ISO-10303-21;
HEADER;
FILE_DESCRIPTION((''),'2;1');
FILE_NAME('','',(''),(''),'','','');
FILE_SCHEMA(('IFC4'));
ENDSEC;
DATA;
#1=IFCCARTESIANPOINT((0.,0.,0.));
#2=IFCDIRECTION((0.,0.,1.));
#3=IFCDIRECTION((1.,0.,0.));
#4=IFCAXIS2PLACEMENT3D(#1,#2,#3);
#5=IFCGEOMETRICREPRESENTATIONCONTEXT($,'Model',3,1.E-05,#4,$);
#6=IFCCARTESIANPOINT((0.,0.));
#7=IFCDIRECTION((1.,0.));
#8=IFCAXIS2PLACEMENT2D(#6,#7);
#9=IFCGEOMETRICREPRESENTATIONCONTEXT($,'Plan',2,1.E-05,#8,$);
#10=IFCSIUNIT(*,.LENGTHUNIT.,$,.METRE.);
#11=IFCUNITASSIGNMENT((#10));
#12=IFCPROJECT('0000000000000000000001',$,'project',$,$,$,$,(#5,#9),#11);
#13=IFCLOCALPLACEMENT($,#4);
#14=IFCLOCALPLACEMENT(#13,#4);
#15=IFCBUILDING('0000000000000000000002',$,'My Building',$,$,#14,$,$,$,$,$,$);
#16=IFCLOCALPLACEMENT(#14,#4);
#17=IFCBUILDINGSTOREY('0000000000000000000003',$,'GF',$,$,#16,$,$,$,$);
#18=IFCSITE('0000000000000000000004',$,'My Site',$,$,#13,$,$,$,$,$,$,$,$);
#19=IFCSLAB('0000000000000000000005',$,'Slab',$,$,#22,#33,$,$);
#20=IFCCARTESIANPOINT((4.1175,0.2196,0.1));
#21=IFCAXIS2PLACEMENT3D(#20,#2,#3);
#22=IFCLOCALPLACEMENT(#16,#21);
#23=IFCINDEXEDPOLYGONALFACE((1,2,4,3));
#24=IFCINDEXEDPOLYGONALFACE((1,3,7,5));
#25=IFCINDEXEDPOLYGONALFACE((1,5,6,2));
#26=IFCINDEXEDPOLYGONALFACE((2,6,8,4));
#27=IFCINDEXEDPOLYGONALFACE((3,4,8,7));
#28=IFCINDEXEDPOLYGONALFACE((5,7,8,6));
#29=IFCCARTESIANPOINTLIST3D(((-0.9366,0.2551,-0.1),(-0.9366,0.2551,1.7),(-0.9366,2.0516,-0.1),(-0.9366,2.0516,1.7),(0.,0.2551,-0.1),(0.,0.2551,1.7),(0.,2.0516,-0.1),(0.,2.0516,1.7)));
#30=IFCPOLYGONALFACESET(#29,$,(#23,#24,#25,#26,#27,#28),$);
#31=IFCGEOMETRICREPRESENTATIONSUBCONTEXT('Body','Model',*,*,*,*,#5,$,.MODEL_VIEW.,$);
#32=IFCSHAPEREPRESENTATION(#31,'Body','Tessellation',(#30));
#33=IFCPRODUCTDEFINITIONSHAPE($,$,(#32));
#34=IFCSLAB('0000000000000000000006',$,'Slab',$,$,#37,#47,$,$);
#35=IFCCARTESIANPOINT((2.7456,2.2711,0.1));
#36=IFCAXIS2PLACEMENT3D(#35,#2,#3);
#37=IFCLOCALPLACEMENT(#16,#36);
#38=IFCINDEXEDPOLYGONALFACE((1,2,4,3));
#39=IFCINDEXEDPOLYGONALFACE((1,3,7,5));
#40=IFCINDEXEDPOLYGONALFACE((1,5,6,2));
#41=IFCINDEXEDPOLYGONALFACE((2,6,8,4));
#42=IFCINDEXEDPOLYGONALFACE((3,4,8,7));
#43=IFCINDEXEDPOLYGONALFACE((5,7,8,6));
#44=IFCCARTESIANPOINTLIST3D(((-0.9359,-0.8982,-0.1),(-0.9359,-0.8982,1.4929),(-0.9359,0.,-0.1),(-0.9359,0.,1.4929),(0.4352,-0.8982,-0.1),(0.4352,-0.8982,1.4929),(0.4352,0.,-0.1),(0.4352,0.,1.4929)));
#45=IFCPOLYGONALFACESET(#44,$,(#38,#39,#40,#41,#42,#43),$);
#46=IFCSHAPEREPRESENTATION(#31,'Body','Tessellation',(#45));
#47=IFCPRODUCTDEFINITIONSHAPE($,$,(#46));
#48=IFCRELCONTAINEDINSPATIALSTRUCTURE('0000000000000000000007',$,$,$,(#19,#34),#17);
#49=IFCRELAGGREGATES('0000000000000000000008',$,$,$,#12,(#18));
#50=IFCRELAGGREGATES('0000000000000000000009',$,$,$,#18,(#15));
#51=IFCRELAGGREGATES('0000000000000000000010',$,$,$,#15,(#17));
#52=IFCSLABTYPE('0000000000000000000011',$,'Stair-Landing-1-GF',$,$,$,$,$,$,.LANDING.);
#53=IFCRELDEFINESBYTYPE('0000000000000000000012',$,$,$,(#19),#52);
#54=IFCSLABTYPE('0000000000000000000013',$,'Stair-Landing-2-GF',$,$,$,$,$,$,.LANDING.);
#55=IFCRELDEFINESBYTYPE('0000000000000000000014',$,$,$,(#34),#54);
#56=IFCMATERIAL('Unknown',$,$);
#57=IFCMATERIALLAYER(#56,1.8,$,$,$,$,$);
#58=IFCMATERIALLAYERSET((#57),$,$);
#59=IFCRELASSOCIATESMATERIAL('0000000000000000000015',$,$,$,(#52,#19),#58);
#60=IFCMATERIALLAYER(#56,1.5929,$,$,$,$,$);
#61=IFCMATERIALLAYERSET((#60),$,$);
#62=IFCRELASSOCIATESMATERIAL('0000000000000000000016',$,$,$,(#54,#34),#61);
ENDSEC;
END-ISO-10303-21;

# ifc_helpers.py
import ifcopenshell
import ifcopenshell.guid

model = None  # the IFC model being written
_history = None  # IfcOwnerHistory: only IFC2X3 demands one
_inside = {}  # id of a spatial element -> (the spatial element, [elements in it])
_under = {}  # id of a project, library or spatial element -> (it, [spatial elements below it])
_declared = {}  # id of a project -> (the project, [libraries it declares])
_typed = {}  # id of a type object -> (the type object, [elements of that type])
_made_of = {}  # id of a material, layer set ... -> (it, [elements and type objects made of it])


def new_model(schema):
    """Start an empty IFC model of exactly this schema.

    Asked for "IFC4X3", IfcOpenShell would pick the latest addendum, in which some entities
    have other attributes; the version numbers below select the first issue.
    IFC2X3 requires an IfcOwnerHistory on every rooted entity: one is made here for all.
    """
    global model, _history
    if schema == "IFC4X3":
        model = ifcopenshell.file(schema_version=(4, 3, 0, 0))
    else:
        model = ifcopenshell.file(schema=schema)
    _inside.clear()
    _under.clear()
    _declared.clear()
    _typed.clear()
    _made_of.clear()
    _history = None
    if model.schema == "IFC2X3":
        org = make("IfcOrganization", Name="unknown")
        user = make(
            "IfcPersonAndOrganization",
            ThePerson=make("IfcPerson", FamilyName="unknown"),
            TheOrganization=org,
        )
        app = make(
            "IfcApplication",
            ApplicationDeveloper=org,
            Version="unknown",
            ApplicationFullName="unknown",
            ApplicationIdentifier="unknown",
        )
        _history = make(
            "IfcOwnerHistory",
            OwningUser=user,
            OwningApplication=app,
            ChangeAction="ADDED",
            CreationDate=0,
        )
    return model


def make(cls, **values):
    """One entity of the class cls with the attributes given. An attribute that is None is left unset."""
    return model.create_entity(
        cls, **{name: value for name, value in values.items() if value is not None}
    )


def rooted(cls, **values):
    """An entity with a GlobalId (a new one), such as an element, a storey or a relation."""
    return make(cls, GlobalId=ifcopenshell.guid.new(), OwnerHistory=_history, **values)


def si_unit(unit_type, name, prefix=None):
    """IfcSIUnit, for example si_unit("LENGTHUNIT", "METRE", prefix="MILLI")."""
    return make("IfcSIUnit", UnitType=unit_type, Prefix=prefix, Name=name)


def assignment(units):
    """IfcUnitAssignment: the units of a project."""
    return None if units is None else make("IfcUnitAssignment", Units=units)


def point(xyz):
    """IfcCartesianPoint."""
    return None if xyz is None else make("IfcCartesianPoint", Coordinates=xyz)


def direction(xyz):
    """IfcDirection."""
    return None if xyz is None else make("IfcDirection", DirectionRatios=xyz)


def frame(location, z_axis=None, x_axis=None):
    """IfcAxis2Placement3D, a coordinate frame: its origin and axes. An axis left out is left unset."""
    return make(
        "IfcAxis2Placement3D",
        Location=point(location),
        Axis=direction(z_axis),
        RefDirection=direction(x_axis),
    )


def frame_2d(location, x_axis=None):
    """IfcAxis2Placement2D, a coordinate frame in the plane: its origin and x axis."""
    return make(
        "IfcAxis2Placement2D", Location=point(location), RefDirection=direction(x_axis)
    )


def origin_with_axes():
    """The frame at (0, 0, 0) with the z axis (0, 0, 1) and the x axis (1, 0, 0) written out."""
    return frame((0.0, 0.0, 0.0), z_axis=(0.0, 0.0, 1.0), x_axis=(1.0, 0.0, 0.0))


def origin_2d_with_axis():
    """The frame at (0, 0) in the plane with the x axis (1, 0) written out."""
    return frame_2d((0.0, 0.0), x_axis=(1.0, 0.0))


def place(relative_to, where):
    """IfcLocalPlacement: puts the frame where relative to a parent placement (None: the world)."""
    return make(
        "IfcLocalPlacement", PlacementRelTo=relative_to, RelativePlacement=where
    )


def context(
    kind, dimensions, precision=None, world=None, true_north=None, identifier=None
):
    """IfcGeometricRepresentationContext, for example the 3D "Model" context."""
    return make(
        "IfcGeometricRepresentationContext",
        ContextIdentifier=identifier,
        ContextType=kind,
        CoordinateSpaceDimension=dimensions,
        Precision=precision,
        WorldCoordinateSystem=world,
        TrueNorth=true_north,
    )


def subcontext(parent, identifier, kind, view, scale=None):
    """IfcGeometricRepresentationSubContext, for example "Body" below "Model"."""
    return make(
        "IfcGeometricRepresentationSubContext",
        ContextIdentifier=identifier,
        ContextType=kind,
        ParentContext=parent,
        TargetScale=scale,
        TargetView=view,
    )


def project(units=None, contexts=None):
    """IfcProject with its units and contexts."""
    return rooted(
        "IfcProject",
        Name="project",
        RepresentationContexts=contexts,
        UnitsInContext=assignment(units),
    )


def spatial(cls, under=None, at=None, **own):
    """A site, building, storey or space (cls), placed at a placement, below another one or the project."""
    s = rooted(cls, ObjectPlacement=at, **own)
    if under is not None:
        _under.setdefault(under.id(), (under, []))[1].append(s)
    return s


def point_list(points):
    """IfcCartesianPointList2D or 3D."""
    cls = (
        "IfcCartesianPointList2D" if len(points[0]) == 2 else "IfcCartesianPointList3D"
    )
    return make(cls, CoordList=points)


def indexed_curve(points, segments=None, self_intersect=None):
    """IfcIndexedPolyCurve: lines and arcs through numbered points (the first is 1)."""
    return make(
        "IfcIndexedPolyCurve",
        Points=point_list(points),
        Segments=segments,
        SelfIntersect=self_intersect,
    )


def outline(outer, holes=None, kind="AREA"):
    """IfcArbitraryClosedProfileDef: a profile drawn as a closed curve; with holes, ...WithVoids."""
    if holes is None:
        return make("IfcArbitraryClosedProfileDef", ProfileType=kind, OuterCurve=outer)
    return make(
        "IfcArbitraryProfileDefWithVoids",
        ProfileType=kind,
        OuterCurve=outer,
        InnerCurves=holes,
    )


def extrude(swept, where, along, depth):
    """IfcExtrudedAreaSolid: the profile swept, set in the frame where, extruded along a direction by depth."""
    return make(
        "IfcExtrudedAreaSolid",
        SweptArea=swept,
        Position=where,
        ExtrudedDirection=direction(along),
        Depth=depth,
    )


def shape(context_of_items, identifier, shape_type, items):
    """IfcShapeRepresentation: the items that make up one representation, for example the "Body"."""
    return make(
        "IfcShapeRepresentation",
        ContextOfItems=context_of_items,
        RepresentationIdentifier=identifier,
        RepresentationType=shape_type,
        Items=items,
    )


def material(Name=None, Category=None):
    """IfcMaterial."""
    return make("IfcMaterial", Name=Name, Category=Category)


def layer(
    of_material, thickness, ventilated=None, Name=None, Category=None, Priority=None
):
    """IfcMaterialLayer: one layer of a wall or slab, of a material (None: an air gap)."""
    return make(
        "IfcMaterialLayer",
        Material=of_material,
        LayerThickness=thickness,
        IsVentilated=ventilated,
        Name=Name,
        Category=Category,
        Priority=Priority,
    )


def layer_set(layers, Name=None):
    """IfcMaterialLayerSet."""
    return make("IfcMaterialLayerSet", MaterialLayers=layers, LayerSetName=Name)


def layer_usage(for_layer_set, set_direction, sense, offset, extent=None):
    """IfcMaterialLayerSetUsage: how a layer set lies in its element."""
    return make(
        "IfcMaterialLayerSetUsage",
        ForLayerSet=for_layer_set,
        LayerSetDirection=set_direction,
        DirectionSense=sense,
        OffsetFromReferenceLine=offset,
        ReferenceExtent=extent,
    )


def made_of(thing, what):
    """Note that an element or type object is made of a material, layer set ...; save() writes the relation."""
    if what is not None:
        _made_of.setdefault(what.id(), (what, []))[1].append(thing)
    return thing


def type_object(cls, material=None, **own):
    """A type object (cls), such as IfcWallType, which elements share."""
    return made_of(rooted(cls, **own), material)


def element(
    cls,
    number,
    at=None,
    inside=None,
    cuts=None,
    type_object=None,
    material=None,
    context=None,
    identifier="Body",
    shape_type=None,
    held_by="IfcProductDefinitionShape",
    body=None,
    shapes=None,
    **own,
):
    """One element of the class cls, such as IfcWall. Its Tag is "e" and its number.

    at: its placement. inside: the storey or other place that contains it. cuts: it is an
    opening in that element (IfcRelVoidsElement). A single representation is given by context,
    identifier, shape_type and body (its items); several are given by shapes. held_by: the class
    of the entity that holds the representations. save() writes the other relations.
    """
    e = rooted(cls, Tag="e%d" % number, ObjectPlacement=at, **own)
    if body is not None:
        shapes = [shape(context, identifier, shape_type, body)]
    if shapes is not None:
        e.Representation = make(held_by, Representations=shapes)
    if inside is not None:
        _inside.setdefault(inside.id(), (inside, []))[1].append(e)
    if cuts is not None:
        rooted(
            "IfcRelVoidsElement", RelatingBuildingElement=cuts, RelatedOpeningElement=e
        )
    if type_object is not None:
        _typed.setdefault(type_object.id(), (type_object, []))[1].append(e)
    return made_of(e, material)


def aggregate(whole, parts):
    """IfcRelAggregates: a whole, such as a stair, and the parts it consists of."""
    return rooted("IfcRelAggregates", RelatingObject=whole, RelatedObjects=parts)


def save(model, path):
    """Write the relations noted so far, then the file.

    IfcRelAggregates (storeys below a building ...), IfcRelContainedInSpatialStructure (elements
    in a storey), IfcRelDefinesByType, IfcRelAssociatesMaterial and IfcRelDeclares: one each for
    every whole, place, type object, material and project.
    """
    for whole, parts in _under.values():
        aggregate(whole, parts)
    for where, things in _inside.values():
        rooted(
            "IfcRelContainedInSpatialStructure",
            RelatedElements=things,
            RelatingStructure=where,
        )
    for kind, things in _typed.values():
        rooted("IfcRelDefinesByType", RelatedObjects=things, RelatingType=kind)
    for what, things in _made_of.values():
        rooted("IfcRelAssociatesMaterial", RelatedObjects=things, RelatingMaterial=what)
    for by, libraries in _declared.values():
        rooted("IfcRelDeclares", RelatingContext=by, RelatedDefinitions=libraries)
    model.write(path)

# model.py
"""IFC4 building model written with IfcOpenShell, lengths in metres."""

from ifc_helpers import new_model, si_unit, frame, origin_with_axes, origin_2d_with_axis, place, context, subcontext, project, spatial, indexed_curve, outline, extrude, material, layer, layer_set, layer_usage, type_object, element, save


model = new_model("IFC4")

# Units and contexts
model_context = context("Model", 3, precision=1e-05, world=origin_with_axes())
plan_context = context("Plan", 2, precision=1e-05, world=origin_2d_with_axis())
body_context_1 = subcontext(model_context, "Body", "Model", "MODEL_VIEW")
ifc_project = project(units=[si_unit("LENGTHUNIT", "METRE")], contexts=[model_context, plan_context])

# Site, building, storey
site_placement = place(None, origin_with_axes())
site = spatial("IfcSite", under=ifc_project, at=site_placement, Name="My Site")
building_placement = place(site_placement, origin_with_axes())
building = spatial("IfcBuilding", under=site, at=building_placement, Name="My Building")
storey_placement = place(building_placement, origin_with_axes())
storey = spatial("IfcBuildingStorey", under=building, at=storey_placement, Name="GF")

# Shared definitions
ifc_material = material(Name="Unknown")

# Slabs
ifc_layer_1 = layer(ifc_material, 1.8)
ifc_layer_set_1 = layer_set([ifc_layer_1])
ifc_layer_usage_1 = layer_usage(ifc_layer_set_1, "AXIS3", "POSITIVE", -0.1)
slab_type_1 = type_object("IfcSlabType", Name="Stair-Landing-1-GF", PredefinedType="LANDING", material=ifc_layer_set_1)
slab_1_placement = place(storey_placement, frame((4.1175, 0.2196, 0.1), z_axis=(0.0, 0.0, 1.0), x_axis=(1.0, 0.0, 0.0)))
element("IfcSlab", 1, at=slab_1_placement, inside=storey, type_object=slab_type_1, material=ifc_layer_usage_1, Name="Slab", context=body_context_1, shape_type="SweptSolid", body=[
    extrude(outline(indexed_curve([(0.0, 0.2551), (0.0, 2.0516), (-0.9366, 2.0516), (-0.9366, 0.2551), (0.0, 0.2551)])), frame((0.0, 0.0, -0.1), z_axis=(0.0, 0.0, 1.0), x_axis=(1.0, 0.0, 0.0)), (0.0, 0.0, 1.0), 1.8),
])
ifc_layer_2 = layer(ifc_material, 1.5929)
ifc_layer_set_2 = layer_set([ifc_layer_2])
ifc_layer_usage_2 = layer_usage(ifc_layer_set_2, "AXIS3", "POSITIVE", -0.1)
slab_type_2 = type_object("IfcSlabType", Name="Stair-Landing-2-GF", PredefinedType="LANDING", material=ifc_layer_set_2)
slab_2_placement = place(storey_placement, frame((2.7456, 2.2711, 0.1), z_axis=(0.0, 0.0, 1.0), x_axis=(1.0, 0.0, 0.0)))
element("IfcSlab", 2, at=slab_2_placement, inside=storey, type_object=slab_type_2, material=ifc_layer_usage_2, Name="Slab", context=body_context_1, shape_type="SweptSolid", body=[
    extrude(outline(indexed_curve([(0.4352, 0.0), (0.4352, -0.8982), (-0.9359, -0.8982), (-0.9359, 0.0), (0.4352, 0.0)])), frame((0.0, 0.0, -0.1), z_axis=(0.0, 0.0, 1.0), x_axis=(1.0, 0.0, 0.0)), (0.0, 0.0, 1.0), 1.5929),
])

save(model, "model.ifc")
